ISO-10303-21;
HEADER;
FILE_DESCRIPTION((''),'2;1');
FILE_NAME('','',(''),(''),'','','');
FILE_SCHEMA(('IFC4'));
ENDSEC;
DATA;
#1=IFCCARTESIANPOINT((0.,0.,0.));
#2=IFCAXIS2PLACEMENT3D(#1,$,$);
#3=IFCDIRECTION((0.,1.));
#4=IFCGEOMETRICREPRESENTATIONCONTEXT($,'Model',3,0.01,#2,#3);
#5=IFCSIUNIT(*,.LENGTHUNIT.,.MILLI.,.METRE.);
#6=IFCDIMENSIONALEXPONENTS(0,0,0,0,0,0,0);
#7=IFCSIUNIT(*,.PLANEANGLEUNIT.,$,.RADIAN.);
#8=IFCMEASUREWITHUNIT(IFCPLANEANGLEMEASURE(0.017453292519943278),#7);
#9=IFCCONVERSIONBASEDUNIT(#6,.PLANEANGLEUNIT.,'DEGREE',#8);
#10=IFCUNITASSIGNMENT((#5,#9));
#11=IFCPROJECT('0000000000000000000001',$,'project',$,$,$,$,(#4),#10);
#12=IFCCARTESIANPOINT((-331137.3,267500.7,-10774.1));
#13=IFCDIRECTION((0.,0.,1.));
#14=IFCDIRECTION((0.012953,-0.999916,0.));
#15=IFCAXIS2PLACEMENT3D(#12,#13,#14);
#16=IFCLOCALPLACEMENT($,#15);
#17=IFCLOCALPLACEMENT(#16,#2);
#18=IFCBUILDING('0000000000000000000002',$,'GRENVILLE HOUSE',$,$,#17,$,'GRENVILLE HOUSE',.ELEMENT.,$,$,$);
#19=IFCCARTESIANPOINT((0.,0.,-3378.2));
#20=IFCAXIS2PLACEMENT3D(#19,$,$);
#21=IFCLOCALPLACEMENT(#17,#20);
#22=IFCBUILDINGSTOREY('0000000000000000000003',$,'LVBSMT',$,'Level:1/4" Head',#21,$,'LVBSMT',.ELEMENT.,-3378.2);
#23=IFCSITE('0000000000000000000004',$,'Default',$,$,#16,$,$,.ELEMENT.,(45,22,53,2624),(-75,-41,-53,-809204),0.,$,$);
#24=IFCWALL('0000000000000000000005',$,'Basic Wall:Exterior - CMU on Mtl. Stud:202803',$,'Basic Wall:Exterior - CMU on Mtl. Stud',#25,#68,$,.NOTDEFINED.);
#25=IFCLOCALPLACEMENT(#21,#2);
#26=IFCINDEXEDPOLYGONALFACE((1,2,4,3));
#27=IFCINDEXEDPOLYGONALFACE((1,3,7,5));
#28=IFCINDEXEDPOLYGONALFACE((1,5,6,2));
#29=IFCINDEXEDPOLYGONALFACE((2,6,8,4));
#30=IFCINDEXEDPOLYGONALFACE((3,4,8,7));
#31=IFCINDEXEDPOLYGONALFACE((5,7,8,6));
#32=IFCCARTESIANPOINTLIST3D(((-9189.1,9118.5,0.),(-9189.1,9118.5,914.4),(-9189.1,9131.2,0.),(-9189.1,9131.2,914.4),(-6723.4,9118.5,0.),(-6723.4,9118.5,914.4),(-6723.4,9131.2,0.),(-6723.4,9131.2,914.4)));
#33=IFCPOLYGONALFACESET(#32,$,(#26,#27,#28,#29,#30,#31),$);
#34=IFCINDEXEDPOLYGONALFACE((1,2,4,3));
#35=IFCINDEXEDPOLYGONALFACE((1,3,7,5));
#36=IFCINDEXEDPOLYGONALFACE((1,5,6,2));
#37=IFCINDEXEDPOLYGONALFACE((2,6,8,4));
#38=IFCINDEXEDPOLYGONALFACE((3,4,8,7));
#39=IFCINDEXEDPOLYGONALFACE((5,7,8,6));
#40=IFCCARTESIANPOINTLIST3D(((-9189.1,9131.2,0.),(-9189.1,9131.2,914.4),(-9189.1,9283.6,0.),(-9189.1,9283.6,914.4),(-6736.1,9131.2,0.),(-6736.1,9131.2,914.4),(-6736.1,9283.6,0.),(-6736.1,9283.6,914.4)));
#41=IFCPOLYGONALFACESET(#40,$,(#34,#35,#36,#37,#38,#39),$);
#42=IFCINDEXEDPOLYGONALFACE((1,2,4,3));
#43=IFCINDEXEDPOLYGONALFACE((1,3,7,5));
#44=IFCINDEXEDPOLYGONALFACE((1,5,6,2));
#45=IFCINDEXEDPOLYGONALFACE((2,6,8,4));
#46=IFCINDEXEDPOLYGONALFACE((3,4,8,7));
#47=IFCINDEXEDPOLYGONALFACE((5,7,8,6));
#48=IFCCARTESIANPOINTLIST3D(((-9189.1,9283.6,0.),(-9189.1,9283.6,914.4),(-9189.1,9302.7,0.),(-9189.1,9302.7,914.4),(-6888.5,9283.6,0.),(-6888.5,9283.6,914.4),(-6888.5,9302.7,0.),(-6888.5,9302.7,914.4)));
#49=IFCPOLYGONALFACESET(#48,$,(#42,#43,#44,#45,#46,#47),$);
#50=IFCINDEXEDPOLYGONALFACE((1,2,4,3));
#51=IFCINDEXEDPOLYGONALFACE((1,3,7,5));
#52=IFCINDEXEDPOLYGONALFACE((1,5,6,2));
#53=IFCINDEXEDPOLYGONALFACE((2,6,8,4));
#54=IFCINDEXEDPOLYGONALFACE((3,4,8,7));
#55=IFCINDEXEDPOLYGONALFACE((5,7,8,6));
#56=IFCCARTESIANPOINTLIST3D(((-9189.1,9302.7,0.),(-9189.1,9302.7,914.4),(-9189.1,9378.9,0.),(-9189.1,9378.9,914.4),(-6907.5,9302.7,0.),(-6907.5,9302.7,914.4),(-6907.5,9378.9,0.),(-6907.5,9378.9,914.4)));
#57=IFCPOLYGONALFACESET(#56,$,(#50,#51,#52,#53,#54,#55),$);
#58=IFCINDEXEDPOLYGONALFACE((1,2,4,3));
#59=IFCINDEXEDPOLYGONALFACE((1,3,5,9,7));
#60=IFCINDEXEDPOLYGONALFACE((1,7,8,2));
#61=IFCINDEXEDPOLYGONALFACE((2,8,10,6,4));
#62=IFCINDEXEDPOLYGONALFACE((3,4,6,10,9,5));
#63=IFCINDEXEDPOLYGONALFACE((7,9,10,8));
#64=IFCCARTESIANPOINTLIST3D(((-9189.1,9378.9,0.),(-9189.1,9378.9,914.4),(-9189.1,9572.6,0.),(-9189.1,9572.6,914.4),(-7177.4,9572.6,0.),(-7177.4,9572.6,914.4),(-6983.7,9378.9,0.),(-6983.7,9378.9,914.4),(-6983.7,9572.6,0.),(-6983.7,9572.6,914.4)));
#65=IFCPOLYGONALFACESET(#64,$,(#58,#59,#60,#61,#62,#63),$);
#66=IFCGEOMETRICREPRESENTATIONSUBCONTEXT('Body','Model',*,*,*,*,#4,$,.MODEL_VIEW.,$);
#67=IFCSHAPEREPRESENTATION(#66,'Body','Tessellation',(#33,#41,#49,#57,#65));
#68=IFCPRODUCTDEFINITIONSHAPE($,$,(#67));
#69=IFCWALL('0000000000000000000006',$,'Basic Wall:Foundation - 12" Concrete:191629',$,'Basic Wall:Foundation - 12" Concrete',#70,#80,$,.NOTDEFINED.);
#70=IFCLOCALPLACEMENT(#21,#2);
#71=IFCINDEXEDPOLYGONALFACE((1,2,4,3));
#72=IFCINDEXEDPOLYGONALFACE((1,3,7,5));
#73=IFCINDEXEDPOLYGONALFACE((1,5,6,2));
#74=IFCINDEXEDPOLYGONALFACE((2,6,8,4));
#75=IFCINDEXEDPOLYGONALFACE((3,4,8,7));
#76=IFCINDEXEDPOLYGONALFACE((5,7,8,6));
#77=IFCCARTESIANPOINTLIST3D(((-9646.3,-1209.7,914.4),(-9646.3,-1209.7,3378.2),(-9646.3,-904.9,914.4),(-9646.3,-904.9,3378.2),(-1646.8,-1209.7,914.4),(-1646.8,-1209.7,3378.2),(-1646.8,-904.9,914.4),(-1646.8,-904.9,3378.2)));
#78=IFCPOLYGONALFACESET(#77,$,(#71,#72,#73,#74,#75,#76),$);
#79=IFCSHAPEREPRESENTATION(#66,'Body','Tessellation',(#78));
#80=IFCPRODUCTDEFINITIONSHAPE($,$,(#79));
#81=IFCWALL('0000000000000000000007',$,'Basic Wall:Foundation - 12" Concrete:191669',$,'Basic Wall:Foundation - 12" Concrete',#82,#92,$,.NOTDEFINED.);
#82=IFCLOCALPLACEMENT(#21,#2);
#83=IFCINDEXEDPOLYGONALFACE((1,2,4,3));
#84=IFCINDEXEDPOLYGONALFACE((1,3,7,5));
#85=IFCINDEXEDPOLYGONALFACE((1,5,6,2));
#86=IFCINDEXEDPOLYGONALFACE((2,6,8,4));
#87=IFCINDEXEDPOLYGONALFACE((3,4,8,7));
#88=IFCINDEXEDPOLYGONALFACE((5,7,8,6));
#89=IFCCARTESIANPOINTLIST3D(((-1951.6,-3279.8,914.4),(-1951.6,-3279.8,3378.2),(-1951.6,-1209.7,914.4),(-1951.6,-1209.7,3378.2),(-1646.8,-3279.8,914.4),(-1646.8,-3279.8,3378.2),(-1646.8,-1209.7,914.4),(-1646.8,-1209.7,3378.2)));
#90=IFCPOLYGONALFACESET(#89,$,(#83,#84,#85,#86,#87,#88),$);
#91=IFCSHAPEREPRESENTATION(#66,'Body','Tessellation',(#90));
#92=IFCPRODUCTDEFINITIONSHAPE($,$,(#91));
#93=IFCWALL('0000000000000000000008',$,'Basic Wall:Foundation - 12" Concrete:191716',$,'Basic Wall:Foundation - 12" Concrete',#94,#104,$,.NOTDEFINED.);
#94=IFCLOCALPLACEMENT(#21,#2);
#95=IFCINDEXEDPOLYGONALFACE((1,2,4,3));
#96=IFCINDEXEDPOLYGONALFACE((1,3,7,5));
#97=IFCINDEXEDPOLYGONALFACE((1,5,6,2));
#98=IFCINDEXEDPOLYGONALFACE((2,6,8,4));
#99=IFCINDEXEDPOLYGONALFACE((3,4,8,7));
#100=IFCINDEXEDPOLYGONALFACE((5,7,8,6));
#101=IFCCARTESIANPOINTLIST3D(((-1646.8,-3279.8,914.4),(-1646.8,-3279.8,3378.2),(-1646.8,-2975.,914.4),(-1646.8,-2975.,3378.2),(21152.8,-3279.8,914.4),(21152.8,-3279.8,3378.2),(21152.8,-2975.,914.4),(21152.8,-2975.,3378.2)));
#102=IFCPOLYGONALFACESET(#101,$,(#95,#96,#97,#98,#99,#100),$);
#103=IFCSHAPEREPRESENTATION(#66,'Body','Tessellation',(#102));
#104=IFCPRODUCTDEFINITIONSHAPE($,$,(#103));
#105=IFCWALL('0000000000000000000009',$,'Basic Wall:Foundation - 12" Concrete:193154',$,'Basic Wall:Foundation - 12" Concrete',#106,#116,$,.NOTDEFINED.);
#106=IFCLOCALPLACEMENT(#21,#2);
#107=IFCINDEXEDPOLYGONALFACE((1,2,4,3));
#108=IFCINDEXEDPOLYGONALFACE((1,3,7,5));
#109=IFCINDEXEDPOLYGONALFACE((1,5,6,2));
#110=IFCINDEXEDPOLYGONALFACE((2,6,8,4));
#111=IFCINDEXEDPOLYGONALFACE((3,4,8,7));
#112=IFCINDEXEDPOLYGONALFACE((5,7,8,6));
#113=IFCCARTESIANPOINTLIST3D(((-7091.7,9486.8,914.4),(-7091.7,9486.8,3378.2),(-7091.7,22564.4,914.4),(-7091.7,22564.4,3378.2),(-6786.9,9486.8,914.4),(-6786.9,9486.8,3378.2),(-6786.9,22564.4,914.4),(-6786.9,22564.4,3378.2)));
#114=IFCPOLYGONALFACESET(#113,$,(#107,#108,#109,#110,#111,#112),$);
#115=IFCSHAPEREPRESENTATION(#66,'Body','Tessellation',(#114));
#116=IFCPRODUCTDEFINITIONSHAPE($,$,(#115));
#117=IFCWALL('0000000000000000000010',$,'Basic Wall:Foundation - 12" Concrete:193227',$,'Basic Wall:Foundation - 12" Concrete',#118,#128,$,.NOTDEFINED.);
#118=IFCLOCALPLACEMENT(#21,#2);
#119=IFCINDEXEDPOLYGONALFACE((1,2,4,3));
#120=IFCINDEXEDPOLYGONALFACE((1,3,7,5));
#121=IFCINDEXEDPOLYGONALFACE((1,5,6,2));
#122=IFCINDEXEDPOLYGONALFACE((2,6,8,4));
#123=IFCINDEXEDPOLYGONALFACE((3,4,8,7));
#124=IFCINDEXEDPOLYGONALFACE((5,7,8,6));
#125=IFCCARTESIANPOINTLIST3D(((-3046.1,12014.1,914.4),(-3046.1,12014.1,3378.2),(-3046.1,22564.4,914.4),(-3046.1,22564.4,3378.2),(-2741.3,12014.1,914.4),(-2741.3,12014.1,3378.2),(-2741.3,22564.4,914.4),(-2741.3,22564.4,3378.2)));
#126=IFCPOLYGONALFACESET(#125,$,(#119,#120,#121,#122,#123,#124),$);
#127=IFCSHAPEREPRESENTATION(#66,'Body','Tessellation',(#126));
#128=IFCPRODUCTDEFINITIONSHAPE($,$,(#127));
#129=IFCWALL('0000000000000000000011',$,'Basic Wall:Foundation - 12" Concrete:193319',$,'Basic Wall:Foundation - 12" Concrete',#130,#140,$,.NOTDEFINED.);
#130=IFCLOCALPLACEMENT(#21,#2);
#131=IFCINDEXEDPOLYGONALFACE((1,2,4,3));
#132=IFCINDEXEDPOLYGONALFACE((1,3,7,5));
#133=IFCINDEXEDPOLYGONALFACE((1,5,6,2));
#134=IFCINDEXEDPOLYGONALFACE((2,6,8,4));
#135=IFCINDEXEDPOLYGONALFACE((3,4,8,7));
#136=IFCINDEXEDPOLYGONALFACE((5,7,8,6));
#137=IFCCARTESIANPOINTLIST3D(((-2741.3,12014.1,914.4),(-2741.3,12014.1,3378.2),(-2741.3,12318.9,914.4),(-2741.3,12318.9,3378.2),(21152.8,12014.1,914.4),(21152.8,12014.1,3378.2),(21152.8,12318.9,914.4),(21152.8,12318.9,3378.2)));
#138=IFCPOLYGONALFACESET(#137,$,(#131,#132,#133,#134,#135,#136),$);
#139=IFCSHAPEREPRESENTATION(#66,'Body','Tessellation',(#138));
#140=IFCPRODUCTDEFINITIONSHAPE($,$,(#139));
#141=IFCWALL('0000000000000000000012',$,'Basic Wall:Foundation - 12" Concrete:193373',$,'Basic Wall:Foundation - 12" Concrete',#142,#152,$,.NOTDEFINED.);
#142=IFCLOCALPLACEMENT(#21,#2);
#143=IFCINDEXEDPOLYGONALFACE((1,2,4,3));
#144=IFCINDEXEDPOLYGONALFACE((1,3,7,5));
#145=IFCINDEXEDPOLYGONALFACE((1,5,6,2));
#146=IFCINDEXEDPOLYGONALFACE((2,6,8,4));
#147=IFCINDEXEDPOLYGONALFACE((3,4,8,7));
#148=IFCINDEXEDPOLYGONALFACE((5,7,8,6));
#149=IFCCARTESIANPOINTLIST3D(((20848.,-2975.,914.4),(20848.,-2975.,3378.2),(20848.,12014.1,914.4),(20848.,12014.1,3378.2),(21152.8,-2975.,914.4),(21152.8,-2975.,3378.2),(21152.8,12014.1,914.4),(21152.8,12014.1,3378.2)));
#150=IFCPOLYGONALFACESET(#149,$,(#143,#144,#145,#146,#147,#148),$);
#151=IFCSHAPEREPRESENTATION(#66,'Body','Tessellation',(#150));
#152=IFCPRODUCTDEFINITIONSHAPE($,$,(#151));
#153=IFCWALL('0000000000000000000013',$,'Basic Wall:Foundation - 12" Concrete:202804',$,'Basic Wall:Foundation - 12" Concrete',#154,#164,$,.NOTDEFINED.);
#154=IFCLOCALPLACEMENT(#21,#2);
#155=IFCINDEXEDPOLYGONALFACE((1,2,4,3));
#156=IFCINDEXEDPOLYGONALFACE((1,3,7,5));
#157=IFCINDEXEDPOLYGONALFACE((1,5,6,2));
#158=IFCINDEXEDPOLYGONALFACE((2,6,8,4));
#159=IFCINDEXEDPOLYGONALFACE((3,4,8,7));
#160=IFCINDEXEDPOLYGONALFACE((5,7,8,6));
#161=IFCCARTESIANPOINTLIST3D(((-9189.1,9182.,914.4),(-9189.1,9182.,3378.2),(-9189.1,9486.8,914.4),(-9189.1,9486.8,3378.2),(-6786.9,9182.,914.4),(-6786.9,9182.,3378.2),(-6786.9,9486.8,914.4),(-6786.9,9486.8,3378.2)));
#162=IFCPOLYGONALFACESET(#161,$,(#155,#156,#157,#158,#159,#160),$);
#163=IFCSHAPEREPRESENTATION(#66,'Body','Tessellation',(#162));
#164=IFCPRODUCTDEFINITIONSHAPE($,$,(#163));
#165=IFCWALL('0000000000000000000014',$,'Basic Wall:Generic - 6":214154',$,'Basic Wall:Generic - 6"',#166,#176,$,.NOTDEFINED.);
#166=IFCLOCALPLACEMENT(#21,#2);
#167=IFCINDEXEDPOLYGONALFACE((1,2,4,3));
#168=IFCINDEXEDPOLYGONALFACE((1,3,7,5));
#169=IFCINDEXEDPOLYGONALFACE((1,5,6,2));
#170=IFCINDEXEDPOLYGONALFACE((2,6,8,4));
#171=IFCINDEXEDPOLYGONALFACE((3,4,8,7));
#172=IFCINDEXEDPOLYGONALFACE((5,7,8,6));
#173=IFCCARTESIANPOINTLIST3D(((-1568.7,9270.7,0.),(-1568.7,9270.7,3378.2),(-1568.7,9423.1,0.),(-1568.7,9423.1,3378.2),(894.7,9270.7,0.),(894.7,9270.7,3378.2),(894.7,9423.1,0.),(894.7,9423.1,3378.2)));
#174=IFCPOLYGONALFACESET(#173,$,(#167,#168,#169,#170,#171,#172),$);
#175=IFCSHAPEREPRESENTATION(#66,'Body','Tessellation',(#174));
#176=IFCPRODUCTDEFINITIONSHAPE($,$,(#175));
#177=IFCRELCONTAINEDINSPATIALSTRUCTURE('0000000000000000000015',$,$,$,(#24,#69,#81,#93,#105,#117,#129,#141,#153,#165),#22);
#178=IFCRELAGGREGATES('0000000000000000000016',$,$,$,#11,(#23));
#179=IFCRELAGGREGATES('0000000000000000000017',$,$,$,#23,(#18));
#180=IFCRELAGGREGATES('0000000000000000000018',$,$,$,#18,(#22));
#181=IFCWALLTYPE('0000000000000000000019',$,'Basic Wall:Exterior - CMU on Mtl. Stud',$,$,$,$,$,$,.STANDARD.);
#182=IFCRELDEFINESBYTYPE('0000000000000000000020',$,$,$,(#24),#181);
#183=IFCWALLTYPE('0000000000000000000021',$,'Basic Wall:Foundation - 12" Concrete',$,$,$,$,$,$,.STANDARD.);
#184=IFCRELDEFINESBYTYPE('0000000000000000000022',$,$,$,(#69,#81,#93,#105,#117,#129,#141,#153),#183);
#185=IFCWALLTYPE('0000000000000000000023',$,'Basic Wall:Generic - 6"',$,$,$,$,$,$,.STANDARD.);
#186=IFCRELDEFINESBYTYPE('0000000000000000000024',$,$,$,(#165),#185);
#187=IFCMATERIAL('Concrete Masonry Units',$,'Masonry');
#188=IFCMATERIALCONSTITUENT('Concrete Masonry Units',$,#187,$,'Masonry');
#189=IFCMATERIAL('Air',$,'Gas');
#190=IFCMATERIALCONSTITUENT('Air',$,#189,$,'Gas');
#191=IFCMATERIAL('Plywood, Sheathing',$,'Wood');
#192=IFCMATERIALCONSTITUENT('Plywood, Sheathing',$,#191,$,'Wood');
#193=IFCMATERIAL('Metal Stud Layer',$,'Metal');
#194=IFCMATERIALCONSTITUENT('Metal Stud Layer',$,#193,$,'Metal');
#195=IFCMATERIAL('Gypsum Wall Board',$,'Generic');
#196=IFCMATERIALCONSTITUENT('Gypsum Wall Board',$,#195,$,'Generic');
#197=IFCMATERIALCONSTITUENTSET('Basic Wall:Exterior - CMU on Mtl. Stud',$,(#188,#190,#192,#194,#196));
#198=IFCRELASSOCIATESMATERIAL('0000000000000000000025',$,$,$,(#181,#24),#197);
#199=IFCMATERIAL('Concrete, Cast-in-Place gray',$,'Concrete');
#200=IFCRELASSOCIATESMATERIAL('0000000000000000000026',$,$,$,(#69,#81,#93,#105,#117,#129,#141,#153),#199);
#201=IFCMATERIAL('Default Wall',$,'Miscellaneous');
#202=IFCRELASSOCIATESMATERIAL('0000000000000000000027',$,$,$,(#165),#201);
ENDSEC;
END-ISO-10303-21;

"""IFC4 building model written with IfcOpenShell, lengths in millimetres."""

from ifc_helpers import new_model, entity, si_unit, converted_unit, direction, frame, origin, place, context, subcontext, project, spatial, indexed_curve, outline, extrude, material, constituent, constituent_set, type_object, element, save


model = new_model("IFC4")

# Units and contexts
model_context = context("Model", 3, precision=0.01, world=origin(), true_north=direction((0.0, 1.0)))
body_context = subcontext(model_context, "Body", "Model", "MODEL_VIEW")
ifc_project = project(units=[si_unit("LENGTHUNIT", "METRE", prefix="MILLI"), converted_unit("PLANEANGLEUNIT", "DEGREE", entity("IfcPlaneAngleMeasure", 0.017453292519943278), si_unit("PLANEANGLEUNIT", "RADIAN"), dimensions=[0, 0, 0, 0, 0, 0, 0])], contexts=[model_context])

# Site, building, storey
site_placement = place(None, frame((-331137.3, 267500.7, -10774.1), z_axis=(0.0, 0.0, 1.0), x_axis=(0.012953, -0.999916, 0.0)))
site = spatial("IfcSite", under=ifc_project, at=site_placement, Name="Default", CompositionType="ELEMENT", RefLatitude=(45, 22, 53, 2624), RefLongitude=(-75, -41, -53, -809204), RefElevation=0.0)
building_placement = place(site_placement, origin())
building = spatial("IfcBuilding", under=site, at=building_placement, Name="GRENVILLE HOUSE", LongName="GRENVILLE HOUSE", CompositionType="ELEMENT")
storey_placement = place(building_placement, frame((0.0, 0.0, -3378.2)))
storey = spatial("IfcBuildingStorey", under=building, at=storey_placement, Name="LVBSMT", ObjectType="Level:1/4\" Head", LongName="LVBSMT", CompositionType="ELEMENT", Elevation=-3378.2)

# Shared definitions
ifc_material_1 = material(Name="Concrete Masonry Units", Category="Masonry")

# Shared definitions
ifc_material_2 = material(Name="Concrete, Cast-in-Place gray", Category="Concrete")

# Walls
ifc_constituent_1 = constituent(ifc_material_1, Name="Concrete Masonry Units", Category="Masonry")
ifc_material_3 = material(Name="Air", Category="Gas")
ifc_constituent_2 = constituent(ifc_material_3, Name="Air", Category="Gas")
ifc_material_4 = material(Name="Plywood, Sheathing", Category="Wood")
ifc_constituent_3 = constituent(ifc_material_4, Name="Plywood, Sheathing", Category="Wood")
ifc_material_5 = material(Name="Metal Stud Layer", Category="Metal")
ifc_constituent_4 = constituent(ifc_material_5, Name="Metal Stud Layer", Category="Metal")
ifc_material_6 = material(Name="Gypsum Wall Board", Category="Generic")
ifc_constituent_5 = constituent(ifc_material_6, Name="Gypsum Wall Board", Category="Generic")
ifc_constituent_set = constituent_set(constituents=[ifc_constituent_1, ifc_constituent_2, ifc_constituent_3, ifc_constituent_4, ifc_constituent_5], Name="Basic Wall:Exterior - CMU on Mtl. Stud")
wall_type_1 = type_object("IfcWallType", Name="Basic Wall:Exterior - CMU on Mtl. Stud", PredefinedType="STANDARD", material=ifc_constituent_set)
wall_1_placement = place(storey_placement, frame((-9189.1, 9345.5, 0.0)))
element("IfcWall", 1, at=wall_1_placement, inside=storey, type_object=wall_type_1, material=ifc_constituent_set, Name="Basic Wall:Exterior - CMU on Mtl. Stud:202803", ObjectType="Basic Wall:Exterior - CMU on Mtl. Stud", PredefinedType="NOTDEFINED", context=body_context, shape_type="SweptSolid", body=[
    extrude(outline(indexed_curve([(-6.4, -1232.8), (6.3, -1232.8), (6.4, 1232.8), (-6.3, 1232.8), (-6.4, -1232.8)], self_intersect=False)), frame((1232.8, -220.7, 0.0), z_axis=(0.0, 0.0, 1.0), x_axis=(0.0, 1.0, 0.0)), (0.0, 0.0, 1.0), 914.4),
    extrude(outline(indexed_curve([(-1226.5, -76.2), (1226.5, -76.2), (1226.5, 76.2), (-1226.5, 76.2), (-1226.5, -76.2)], self_intersect=False)), frame((1226.5, -138.1, 0.0)), (0.0, 0.0, 1.0), 914.4),
    extrude(outline(indexed_curve([(-1150.3, -9.5), (1150.3, -9.5), (1150.3, 9.5), (-1150.3, 9.5), (-1150.3, -9.5)], self_intersect=False)), frame((1150.3, -52.4, 0.0)), (0.0, 0.0, 1.0), 914.4),
    extrude(outline(indexed_curve([(-1140.8, -38.1), (1140.8, -38.1), (1140.8, 38.1), (-1140.8, 38.1), (-1140.8, -38.1)], self_intersect=False)), frame((1140.8, -4.8, 0.0)), (0.0, 0.0, 1.0), 914.4),
    extrude(outline(indexed_curve([(-727.2, -77.5), (1284.5, -77.5), (1284.5, 116.2), (-920.9, 116.2), (-920.9, -77.5), (-727.2, -77.5)], self_intersect=False)), frame((1284.5, 149.5, 0.0), z_axis=(0.0, 0.0, 1.0), x_axis=(-1.0, 0.0, 0.0)), (0.0, 0.0, 1.0), 914.4),
])
wall_type_2 = type_object("IfcWallType", Name="Basic Wall:Foundation - 12\" Concrete", PredefinedType="STANDARD")
wall_2_placement = place(storey_placement, frame((-9646.3, -1057.3, 914.4)))
element("IfcWall", 2, at=wall_2_placement, inside=storey, type_object=wall_type_2, material=ifc_material_2, Name="Basic Wall:Foundation - 12\" Concrete:191629", ObjectType="Basic Wall:Foundation - 12\" Concrete", PredefinedType="NOTDEFINED", context=body_context, shape_type="SweptSolid", body=[
    extrude(outline(indexed_curve([(7999.4, 152.4), (0.0, 152.4), (0.0, -152.4), (7999.4, -152.4), (7999.4, 152.4)], self_intersect=False)), origin(), (0.0, 0.0, 1.0), 2463.8),
])
wall_3_placement = place(storey_placement, frame((-1799.2, -1209.7, 914.4), z_axis=(0.0, 0.0, 1.0), x_axis=(0.0, -1.0, 0.0)))
element("IfcWall", 3, at=wall_3_placement, inside=storey, type_object=wall_type_2, material=ifc_material_2, Name="Basic Wall:Foundation - 12\" Concrete:191669", ObjectType="Basic Wall:Foundation - 12\" Concrete", PredefinedType="NOTDEFINED", context=body_context, shape_type="SweptSolid", body=[
    extrude(outline(indexed_curve([(2070.1, 152.4), (0.0, 152.4), (0.0, -152.4), (2070.1, -152.4), (2070.1, 152.4)], self_intersect=False)), origin(), (0.0, 0.0, 1.0), 2463.8),
])
wall_4_placement = place(storey_placement, frame((-1646.8, -3127.4, 914.4)))
element("IfcWall", 4, at=wall_4_placement, inside=storey, type_object=wall_type_2, material=ifc_material_2, Name="Basic Wall:Foundation - 12\" Concrete:191716", ObjectType="Basic Wall:Foundation - 12\" Concrete", PredefinedType="NOTDEFINED", context=body_context, shape_type="SweptSolid", body=[
    extrude(outline(indexed_curve([(22799.7, 152.4), (0.0, 152.4), (0.0, -152.4), (22799.7, -152.4), (22799.7, 152.4)], self_intersect=False)), origin(), (0.0, 0.0, 1.0), 2463.8),
])
wall_5_placement = place(storey_placement, frame((-6939.3, 9486.8, 914.4), z_axis=(0.0, 0.0, 1.0), x_axis=(0.0, 1.0, 0.0)))
element("IfcWall", 5, at=wall_5_placement, inside=storey, type_object=wall_type_2, material=ifc_material_2, Name="Basic Wall:Foundation - 12\" Concrete:193154", ObjectType="Basic Wall:Foundation - 12\" Concrete", PredefinedType="NOTDEFINED", context=body_context, shape_type="SweptSolid", body=[
    extrude(outline(indexed_curve([(13077.6, 152.4), (0.0, 152.4), (0.0, -152.4), (13077.6, -152.4), (13077.6, 152.4)], self_intersect=False)), origin(), (0.0, 0.0, 1.0), 2463.8),
])
wall_6_placement = place(storey_placement, frame((-2893.7, 22564.4, 914.4), z_axis=(0.0, 0.0, 1.0), x_axis=(0.0, -1.0, 0.0)))
element("IfcWall", 6, at=wall_6_placement, inside=storey, type_object=wall_type_2, material=ifc_material_2, Name="Basic Wall:Foundation - 12\" Concrete:193227", ObjectType="Basic Wall:Foundation - 12\" Concrete", PredefinedType="NOTDEFINED", context=body_context, shape_type="SweptSolid", body=[
    extrude(outline(indexed_curve([(10550.3, 152.4), (0.0, 152.4), (0.0, -152.4), (10550.3, -152.4), (10550.3, 152.4)], self_intersect=False)), origin(), (0.0, 0.0, 1.0), 2463.8),
])
wall_7_placement = place(storey_placement, frame((-2741.3, 12166.5, 914.4)))
element("IfcWall", 7, at=wall_7_placement, inside=storey, type_object=wall_type_2, material=ifc_material_2, Name="Basic Wall:Foundation - 12\" Concrete:193319", ObjectType="Basic Wall:Foundation - 12\" Concrete", PredefinedType="NOTDEFINED", context=body_context, shape_type="SweptSolid", body=[
    extrude(outline(indexed_curve([(23894.1, 152.4), (0.0, 152.4), (0.0, -152.4), (23894.1, -152.4), (23894.1, 152.4)], self_intersect=False)), origin(), (0.0, 0.0, 1.0), 2463.8),
])
wall_8_placement = place(storey_placement, frame((21000.4, 12014.1, 914.4), z_axis=(0.0, 0.0, 1.0), x_axis=(0.0, -1.0, 0.0)))
element("IfcWall", 8, at=wall_8_placement, inside=storey, type_object=wall_type_2, material=ifc_material_2, Name="Basic Wall:Foundation - 12\" Concrete:193373", ObjectType="Basic Wall:Foundation - 12\" Concrete", PredefinedType="NOTDEFINED", context=body_context, shape_type="SweptSolid", body=[
    extrude(outline(indexed_curve([(14989.2, 152.4), (0.0, 152.4), (0.0, -152.4), (14989.2, -152.4), (14989.2, 152.4)], self_intersect=False)), origin(), (0.0, 0.0, 1.0), 2463.8),
])
wall_9_placement = place(storey_placement, frame((-9189.1, 9334.4, 914.4)))
element("IfcWall", 9, at=wall_9_placement, inside=storey, type_object=wall_type_2, material=ifc_material_2, Name="Basic Wall:Foundation - 12\" Concrete:202804", ObjectType="Basic Wall:Foundation - 12\" Concrete", PredefinedType="NOTDEFINED", context=body_context, shape_type="SweptSolid", body=[
    extrude(outline(indexed_curve([(2402.2, 152.4), (0.0, 152.4), (0.0, -152.4), (2402.2, -152.4), (2402.2, 152.4)], self_intersect=False)), origin(), (0.0, 0.0, 1.0), 2463.8),
])
ifc_material_7 = material(Name="Default Wall", Category="Miscellaneous")
wall_type_3 = type_object("IfcWallType", Name="Basic Wall:Generic - 6\"", PredefinedType="STANDARD")
wall_10_placement = place(storey_placement, frame((894.7, 9346.9, 0.0), z_axis=(0.0, 0.0, 1.0), x_axis=(-1.0, 0.0, 0.0)))
element("IfcWall", 10, at=wall_10_placement, inside=storey, type_object=wall_type_3, material=ifc_material_7, Name="Basic Wall:Generic - 6\":214154", ObjectType="Basic Wall:Generic - 6\"", PredefinedType="NOTDEFINED", context=body_context, shape_type="SweptSolid", body=[
    extrude(outline(indexed_curve([(2463.5, 76.2), (0.0, 76.2), (0.0, -76.2), (2463.5, -76.2), (2463.5, 76.2)], self_intersect=False)), origin(), (0.0, 0.0, 1.0), 3378.2),
])

save(model, "model.ifc")
